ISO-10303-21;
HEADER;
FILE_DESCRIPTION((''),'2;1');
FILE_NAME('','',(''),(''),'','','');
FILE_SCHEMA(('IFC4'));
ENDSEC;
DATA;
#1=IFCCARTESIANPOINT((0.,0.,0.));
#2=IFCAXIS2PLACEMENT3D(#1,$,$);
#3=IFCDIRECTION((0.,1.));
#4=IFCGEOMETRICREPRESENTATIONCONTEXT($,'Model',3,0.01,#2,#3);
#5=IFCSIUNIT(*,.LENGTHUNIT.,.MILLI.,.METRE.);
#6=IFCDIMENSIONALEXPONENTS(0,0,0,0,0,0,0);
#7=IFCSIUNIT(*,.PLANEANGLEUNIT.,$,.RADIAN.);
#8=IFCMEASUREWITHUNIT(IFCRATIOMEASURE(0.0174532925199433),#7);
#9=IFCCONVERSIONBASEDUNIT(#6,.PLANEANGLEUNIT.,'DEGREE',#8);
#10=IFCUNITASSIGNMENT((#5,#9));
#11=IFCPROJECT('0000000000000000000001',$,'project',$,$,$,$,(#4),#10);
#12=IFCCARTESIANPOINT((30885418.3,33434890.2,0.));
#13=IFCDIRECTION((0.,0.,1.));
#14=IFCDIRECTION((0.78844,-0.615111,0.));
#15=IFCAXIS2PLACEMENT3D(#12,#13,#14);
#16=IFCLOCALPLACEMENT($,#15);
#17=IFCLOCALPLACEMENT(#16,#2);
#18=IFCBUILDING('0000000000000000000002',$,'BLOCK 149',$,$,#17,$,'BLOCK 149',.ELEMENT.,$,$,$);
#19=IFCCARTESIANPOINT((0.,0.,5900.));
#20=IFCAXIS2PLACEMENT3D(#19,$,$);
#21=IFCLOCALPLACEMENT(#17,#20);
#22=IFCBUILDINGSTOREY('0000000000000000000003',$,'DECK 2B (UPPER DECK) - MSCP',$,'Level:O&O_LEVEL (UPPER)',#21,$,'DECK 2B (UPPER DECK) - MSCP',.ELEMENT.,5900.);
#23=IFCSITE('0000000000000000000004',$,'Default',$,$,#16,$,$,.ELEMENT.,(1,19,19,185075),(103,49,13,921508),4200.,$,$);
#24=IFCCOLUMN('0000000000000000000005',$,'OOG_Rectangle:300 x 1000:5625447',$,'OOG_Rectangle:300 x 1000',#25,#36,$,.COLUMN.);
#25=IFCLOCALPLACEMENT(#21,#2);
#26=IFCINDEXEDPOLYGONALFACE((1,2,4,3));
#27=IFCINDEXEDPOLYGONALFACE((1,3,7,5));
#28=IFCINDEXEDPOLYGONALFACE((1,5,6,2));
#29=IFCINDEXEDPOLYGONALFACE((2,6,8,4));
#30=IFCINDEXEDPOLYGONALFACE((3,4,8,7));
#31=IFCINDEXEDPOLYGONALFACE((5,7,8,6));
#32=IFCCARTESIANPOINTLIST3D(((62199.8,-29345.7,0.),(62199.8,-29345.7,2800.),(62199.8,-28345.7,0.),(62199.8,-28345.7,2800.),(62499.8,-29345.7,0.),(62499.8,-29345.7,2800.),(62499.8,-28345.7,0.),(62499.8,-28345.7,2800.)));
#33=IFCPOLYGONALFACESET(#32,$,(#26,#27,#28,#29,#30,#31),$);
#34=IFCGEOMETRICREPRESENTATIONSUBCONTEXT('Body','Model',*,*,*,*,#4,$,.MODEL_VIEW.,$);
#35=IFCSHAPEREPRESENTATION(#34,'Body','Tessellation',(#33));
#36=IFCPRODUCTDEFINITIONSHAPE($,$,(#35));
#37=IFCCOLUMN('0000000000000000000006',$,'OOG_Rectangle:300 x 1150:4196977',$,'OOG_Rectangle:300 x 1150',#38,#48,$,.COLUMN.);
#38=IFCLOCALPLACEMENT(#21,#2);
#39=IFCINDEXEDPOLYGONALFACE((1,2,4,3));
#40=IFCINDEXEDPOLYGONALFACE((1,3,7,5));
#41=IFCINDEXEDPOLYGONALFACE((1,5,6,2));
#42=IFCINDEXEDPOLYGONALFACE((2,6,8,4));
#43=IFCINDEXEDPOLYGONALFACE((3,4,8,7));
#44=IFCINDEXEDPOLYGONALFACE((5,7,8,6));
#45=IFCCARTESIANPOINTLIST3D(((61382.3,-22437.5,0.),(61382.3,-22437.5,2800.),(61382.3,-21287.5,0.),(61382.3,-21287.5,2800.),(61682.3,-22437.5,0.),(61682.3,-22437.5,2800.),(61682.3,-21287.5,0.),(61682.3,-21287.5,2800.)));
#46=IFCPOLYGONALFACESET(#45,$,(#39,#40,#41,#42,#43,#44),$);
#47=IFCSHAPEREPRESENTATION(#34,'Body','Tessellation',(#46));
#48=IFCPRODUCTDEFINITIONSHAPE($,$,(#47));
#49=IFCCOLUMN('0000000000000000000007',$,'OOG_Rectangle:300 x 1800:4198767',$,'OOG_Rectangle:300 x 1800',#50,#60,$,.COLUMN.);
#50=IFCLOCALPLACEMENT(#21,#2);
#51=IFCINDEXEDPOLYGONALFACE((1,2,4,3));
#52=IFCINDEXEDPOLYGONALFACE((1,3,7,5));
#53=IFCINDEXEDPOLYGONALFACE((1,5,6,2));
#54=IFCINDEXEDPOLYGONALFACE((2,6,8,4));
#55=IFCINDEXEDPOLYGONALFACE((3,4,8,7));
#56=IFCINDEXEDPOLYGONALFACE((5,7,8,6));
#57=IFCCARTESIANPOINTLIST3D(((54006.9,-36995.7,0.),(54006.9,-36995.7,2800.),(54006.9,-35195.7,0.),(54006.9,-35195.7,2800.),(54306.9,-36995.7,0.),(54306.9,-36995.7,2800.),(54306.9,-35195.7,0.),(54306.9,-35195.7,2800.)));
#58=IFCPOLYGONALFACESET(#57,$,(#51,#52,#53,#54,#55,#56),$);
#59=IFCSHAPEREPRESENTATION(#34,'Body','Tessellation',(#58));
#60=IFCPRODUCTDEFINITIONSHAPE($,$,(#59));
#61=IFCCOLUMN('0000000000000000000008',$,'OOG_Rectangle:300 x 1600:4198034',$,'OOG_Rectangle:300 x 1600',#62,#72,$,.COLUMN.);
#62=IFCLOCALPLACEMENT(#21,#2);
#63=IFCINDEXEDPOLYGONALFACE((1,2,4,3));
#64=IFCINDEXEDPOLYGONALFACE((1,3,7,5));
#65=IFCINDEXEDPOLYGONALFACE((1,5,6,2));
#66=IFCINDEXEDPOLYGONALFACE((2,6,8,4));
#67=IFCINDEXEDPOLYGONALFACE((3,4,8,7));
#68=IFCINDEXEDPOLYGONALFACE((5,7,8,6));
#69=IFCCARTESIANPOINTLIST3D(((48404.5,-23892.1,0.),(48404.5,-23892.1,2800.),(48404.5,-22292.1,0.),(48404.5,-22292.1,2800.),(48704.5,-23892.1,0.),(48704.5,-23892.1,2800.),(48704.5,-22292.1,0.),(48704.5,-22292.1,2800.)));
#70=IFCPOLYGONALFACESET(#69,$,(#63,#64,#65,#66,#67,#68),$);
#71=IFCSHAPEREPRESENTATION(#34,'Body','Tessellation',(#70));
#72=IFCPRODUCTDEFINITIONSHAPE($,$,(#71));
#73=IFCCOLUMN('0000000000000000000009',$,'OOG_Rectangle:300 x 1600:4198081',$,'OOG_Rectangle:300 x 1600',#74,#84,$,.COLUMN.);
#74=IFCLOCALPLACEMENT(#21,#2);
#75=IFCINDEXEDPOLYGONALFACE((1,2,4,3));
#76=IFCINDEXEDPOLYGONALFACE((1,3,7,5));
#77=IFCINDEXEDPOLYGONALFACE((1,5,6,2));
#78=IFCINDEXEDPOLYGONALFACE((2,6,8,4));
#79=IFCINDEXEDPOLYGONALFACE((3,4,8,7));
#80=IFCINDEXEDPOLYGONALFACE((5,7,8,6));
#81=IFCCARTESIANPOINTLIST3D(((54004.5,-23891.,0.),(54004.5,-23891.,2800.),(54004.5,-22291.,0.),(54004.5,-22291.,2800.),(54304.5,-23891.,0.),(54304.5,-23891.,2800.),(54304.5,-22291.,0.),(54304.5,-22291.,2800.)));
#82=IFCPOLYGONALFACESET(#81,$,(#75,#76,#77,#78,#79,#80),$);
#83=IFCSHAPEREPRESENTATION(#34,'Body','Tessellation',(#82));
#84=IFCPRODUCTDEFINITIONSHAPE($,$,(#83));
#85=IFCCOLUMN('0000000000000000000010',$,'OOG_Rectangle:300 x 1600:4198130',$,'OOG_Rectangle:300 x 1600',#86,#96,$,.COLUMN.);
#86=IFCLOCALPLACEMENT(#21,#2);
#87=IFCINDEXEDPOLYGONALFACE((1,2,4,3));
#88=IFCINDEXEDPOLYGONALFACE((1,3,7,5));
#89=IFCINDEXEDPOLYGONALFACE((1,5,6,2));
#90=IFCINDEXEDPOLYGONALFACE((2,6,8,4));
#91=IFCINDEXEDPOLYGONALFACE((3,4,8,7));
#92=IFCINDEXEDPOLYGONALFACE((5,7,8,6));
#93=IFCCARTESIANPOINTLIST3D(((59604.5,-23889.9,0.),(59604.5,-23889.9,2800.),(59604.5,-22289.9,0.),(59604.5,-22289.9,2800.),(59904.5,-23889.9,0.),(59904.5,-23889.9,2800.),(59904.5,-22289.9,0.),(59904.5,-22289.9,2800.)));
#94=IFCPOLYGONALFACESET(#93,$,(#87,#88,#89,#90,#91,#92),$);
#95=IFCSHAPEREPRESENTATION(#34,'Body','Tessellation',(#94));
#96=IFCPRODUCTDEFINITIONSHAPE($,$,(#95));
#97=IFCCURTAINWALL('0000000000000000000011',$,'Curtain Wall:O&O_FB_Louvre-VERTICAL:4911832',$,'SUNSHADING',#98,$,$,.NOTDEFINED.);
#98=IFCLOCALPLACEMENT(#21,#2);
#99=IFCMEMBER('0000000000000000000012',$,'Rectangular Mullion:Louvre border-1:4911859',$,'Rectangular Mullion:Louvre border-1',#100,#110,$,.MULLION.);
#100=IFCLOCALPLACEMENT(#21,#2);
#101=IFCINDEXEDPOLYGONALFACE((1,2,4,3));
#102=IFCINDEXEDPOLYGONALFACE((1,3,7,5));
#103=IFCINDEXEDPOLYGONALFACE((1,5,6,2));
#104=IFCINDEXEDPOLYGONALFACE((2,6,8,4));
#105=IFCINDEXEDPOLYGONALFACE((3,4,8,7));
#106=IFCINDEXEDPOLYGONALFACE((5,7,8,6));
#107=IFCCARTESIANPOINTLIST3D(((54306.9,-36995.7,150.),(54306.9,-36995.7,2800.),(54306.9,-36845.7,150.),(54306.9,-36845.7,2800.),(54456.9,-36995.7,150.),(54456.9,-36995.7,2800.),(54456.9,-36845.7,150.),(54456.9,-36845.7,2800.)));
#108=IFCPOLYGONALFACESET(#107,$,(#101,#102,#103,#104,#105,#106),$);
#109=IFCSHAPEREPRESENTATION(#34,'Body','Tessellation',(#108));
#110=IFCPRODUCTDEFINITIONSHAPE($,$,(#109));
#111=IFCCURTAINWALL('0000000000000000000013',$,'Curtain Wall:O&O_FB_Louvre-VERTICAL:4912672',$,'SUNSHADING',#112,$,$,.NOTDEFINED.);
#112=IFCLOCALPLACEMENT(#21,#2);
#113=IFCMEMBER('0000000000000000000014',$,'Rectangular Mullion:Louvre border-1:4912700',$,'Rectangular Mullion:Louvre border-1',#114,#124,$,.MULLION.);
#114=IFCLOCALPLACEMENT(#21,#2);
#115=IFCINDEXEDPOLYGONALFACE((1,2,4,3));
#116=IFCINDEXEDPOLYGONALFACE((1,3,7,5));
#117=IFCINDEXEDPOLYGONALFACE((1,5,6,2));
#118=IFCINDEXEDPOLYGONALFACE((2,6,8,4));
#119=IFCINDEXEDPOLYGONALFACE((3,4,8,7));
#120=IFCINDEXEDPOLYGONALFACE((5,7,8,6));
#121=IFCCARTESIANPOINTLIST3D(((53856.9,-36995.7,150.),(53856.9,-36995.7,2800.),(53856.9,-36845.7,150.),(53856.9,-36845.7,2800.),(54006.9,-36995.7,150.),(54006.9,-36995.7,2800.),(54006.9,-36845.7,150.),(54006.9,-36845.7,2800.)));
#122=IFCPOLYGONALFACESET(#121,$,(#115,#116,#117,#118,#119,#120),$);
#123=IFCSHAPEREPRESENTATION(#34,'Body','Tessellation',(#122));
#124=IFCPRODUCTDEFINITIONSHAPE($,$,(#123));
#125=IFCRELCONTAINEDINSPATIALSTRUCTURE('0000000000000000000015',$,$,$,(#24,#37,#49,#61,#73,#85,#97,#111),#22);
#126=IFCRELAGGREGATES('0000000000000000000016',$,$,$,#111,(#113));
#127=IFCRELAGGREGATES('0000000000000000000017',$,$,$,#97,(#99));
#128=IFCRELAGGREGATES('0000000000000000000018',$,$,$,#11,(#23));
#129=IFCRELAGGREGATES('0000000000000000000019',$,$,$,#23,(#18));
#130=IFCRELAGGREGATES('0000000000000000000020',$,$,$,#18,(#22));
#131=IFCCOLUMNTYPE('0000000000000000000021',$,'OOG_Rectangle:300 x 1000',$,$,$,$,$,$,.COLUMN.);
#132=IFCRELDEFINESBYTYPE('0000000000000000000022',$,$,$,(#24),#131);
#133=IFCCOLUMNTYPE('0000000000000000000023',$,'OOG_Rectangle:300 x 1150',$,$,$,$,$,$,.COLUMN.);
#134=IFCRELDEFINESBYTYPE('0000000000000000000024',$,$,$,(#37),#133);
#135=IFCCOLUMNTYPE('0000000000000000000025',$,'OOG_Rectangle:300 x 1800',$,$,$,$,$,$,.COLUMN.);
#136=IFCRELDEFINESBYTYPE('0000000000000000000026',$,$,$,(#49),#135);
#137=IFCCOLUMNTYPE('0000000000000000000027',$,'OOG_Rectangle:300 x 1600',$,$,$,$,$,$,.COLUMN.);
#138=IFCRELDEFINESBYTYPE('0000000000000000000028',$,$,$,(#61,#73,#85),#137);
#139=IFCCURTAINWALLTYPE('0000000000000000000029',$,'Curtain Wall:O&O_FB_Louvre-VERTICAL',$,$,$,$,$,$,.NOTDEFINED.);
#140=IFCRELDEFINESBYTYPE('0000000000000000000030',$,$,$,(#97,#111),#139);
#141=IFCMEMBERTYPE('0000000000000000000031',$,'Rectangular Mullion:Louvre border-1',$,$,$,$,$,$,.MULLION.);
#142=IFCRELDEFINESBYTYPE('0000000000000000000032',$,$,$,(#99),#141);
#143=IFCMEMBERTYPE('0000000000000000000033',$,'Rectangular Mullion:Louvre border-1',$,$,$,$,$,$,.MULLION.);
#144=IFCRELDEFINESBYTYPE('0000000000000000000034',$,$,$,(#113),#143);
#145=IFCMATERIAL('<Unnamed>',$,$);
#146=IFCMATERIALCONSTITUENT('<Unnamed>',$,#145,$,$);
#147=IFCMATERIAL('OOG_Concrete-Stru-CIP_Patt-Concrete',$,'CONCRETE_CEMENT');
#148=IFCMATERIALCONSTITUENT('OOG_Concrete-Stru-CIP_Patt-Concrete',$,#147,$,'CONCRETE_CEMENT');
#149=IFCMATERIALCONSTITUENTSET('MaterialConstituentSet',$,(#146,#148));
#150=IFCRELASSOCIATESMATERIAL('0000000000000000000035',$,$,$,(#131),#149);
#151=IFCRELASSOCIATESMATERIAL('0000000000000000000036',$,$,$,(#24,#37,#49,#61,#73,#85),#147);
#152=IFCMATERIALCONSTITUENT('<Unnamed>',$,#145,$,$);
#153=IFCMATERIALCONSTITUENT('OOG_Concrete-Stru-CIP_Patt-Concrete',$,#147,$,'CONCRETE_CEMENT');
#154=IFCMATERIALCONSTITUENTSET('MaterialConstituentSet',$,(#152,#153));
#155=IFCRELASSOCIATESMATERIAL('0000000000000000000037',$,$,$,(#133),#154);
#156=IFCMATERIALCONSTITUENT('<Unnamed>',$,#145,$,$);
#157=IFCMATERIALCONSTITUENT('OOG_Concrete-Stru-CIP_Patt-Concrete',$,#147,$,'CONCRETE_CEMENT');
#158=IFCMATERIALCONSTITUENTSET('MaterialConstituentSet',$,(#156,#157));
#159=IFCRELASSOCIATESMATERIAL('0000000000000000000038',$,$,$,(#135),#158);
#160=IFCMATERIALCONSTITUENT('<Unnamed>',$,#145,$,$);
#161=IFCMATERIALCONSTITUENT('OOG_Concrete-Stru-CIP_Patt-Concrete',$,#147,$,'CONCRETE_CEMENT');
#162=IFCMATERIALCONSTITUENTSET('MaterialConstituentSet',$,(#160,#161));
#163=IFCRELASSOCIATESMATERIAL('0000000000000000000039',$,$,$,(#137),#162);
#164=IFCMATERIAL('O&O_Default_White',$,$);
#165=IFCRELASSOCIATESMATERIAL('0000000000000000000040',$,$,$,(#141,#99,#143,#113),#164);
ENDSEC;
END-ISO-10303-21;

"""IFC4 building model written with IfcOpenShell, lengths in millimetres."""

from ifc_helpers import new_model, entity, si_unit, converted_unit, direction, frame, origin, place, context, subcontext, project, spatial, indexed_curve, outline, extrude, source, transform, mapped, material, constituent, constituent_set, type_object, type_shapes, element, aggregate, save


model = new_model("IFC4")

# Units and contexts
model_context = context("Model", 3, precision=0.01, world=origin(), true_north=direction((0.0, 1.0)))
body_context = subcontext(model_context, "Body", "Model", "MODEL_VIEW")
ifc_project = project(units=[si_unit("LENGTHUNIT", "METRE", prefix="MILLI"), converted_unit("PLANEANGLEUNIT", "DEGREE", entity("IfcRatioMeasure", 0.0174532925199433), si_unit("PLANEANGLEUNIT", "RADIAN"), dimensions=[0, 0, 0, 0, 0, 0, 0])], contexts=[model_context])

# Site, building, storey
site_placement = place(None, frame((30885418.3, 33434890.2, 0.0), z_axis=(0.0, 0.0, 1.0), x_axis=(0.78844, -0.615111, 0.0)))
site = spatial("IfcSite", under=ifc_project, at=site_placement, Name="Default", CompositionType="ELEMENT", RefLatitude=(1, 19, 19, 185075), RefLongitude=(103, 49, 13, 921508), RefElevation=4200.0)
building_placement = place(site_placement, origin())
building = spatial("IfcBuilding", under=site, at=building_placement, Name="BLOCK 149", LongName="BLOCK 149", CompositionType="ELEMENT")
storey_placement = place(building_placement, frame((0.0, 0.0, 5900.0)))
storey = spatial("IfcBuildingStorey", under=building, at=storey_placement, Name="DECK 2B (UPPER DECK) - MSCP", ObjectType="Level:O&O_LEVEL (UPPER)", LongName="DECK 2B (UPPER DECK) - MSCP", CompositionType="ELEMENT", Elevation=5900.0)

# Columns
ifc_material_1 = material(Name="OOG_Concrete-Stru-CIP_Patt-Concrete", Category="CONCRETE_CEMENT")
ifc_material_2 = material(Name="<Unnamed>")
ifc_constituent_1 = constituent(ifc_material_2, Name="<Unnamed>")
ifc_constituent_2 = constituent(ifc_material_1, Name="OOG_Concrete-Stru-CIP_Patt-Concrete", Category="CONCRETE_CEMENT")
ifc_constituent_set_1 = constituent_set(constituents=[ifc_constituent_1, ifc_constituent_2], Name="MaterialConstituentSet")
column_type_1 = type_object("IfcColumnType", Name="OOG_Rectangle:300 x 1000", PredefinedType="COLUMN", material=ifc_constituent_set_1)
shared_shape_1 = source(origin(), body_context, "Body", "SweptSolid", [
    extrude(outline(indexed_curve([(-500.0, -150.0), (500.0, -150.0), (500.0, 150.0), (-500.0, 150.0), (-500.0, -150.0)], self_intersect=False)), frame((0.0, 0.0, 5900.0), z_axis=(0.0, 0.0, 1.0), x_axis=(0.0, -1.0, 0.0)), (0.0, 0.0, 1.0), 2800.0),
])
type_shapes(column_type_1, [shared_shape_1])
column_1_placement = place(storey_placement, frame((62349.8, -28845.7, -5900.0)))
element("IfcColumn", 1, at=column_1_placement, inside=storey, type_object=column_type_1, material=ifc_material_1, Name="OOG_Rectangle:300 x 1000:5625447", ObjectType="OOG_Rectangle:300 x 1000", PredefinedType="COLUMN", context=body_context, shape_type="MappedRepresentation", body=[
    mapped(shared_shape_1, transform((0.0, 0.0, 0.0), scale=1.0)),
])
ifc_constituent_3 = constituent(ifc_material_2, Name="<Unnamed>")
ifc_constituent_4 = constituent(ifc_material_1, Name="OOG_Concrete-Stru-CIP_Patt-Concrete", Category="CONCRETE_CEMENT")
ifc_constituent_set_2 = constituent_set(constituents=[ifc_constituent_3, ifc_constituent_4], Name="MaterialConstituentSet")
column_type_2 = type_object("IfcColumnType", Name="OOG_Rectangle:300 x 1150", PredefinedType="COLUMN", material=ifc_constituent_set_2)
shared_shape_2 = source(origin(), body_context, "Body", "SweptSolid", [
    extrude(outline(indexed_curve([(-575.0, -150.0), (575.0, -150.0), (575.0, 150.0), (-575.0, 150.0), (-575.0, -150.0)], self_intersect=False)), frame((0.0, 0.0, 5900.0), z_axis=(0.0, 0.0, 1.0), x_axis=(0.0, -1.0, 0.0)), (0.0, 0.0, 1.0), 2800.0),
])
type_shapes(column_type_2, [shared_shape_2])
column_2_placement = place(storey_placement, frame((61532.3, -21862.5, -5900.0), z_axis=(0.0, 0.0, 1.0), x_axis=(-1.0, 0.0, 0.0)))
element("IfcColumn", 2, at=column_2_placement, inside=storey, type_object=column_type_2, material=ifc_material_1, Name="OOG_Rectangle:300 x 1150:4196977", ObjectType="OOG_Rectangle:300 x 1150", PredefinedType="COLUMN", context=body_context, shape_type="MappedRepresentation", body=[
    mapped(shared_shape_2, transform((0.0, 0.0, 0.0), scale=1.0)),
])
ifc_constituent_5 = constituent(ifc_material_2, Name="<Unnamed>")
ifc_constituent_6 = constituent(ifc_material_1, Name="OOG_Concrete-Stru-CIP_Patt-Concrete", Category="CONCRETE_CEMENT")
ifc_constituent_set_3 = constituent_set(constituents=[ifc_constituent_5, ifc_constituent_6], Name="MaterialConstituentSet")
column_type_3 = type_object("IfcColumnType", Name="OOG_Rectangle:300 x 1800", PredefinedType="COLUMN", material=ifc_constituent_set_3)
shared_shape_3 = source(origin(), body_context, "Body", "SweptSolid", [
    extrude(outline(indexed_curve([(-900.0, -150.0), (900.0, -150.0), (900.0, 150.0), (-900.0, 150.0), (-900.0, -150.0)], self_intersect=False)), frame((0.0, 0.0, 5900.0), z_axis=(0.0, 0.0, 1.0), x_axis=(0.0, -1.0, 0.0)), (0.0, 0.0, 1.0), 2800.0),
])
type_shapes(column_type_3, [shared_shape_3])
column_3_placement = place(storey_placement, frame((54156.9, -36095.7, -5900.0)))
element("IfcColumn", 3, at=column_3_placement, inside=storey, type_object=column_type_3, material=ifc_material_1, Name="OOG_Rectangle:300 x 1800:4198767", ObjectType="OOG_Rectangle:300 x 1800", PredefinedType="COLUMN", context=body_context, shape_type="MappedRepresentation", body=[
    mapped(shared_shape_3, transform((0.0, 0.0, 0.0), scale=1.0)),
])
ifc_constituent_7 = constituent(ifc_material_2, Name="<Unnamed>")
ifc_constituent_8 = constituent(ifc_material_1, Name="OOG_Concrete-Stru-CIP_Patt-Concrete", Category="CONCRETE_CEMENT")
ifc_constituent_set_4 = constituent_set(constituents=[ifc_constituent_7, ifc_constituent_8], Name="MaterialConstituentSet")
column_type_4 = type_object("IfcColumnType", Name="OOG_Rectangle:300 x 1600", PredefinedType="COLUMN", material=ifc_constituent_set_4)
shared_shape_4 = source(origin(), body_context, "Body", "SweptSolid", [
    extrude(outline(indexed_curve([(-800.0, -150.0), (800.0, -150.0), (800.0, 150.0), (-800.0, 150.0), (-800.0, -150.0)], self_intersect=False)), frame((0.0, 0.0, 5900.0), z_axis=(0.0, 0.0, 1.0), x_axis=(0.0, -1.0, 0.0)), (0.0, 0.0, 1.0), 2800.0),
])
type_shapes(column_type_4, [shared_shape_4])
for number, where, name in (
    (4, (48554.5, -23092.1, -5900.0), "OOG_Rectangle:300 x 1600:4198034"),
    (5, (54154.5, -23091.0, -5900.0), "OOG_Rectangle:300 x 1600:4198081"),
    (6, (59754.5, -23089.9, -5900.0), "OOG_Rectangle:300 x 1600:4198130"),
):
    element("IfcColumn", number, at=place(storey_placement, frame(where)), inside=storey, type_object=column_type_4, material=ifc_material_1, Name=name, ObjectType="OOG_Rectangle:300 x 1600", PredefinedType="COLUMN", context=body_context, shape_type="MappedRepresentation", body=[
        mapped(shared_shape_4, transform((0.0, 0.0, 0.0), scale=1.0)),
    ])

# Curtain walls, members
curtain_wall_type = type_object("IfcCurtainWallType", Name="Curtain Wall:O&O_FB_Louvre-VERTICAL", PredefinedType="NOTDEFINED")
curtain_wall_1_placement = place(storey_placement, frame((0.0, 0.0, -5900.0)))
curtain_wall_1 = element("IfcCurtainWall", 7, at=curtain_wall_1_placement, inside=storey, type_object=curtain_wall_type, Name="Curtain Wall:O&O_FB_Louvre-VERTICAL:4911832", ObjectType="SUNSHADING", PredefinedType="NOTDEFINED")
ifc_material_3 = material(Name="O&O_Default_White")
member_type_1 = type_object("IfcMemberType", Name="Rectangular Mullion:Louvre border-1", PredefinedType="MULLION", material=ifc_material_3)
shared_shape_5 = source(origin(), body_context, "Body", "SweptSolid", [
    extrude(outline(indexed_curve([(-75.0, -75.0), (75.0, -75.0), (75.0, 75.0), (-75.0, 75.0), (-75.0, -75.0)], self_intersect=False)), frame((-75.0, 0.0, -2650.0), z_axis=(0.0, 0.0, 1.0), x_axis=(0.0, -1.0, 0.0)), (0.0, 0.0, 1.0), 2650.0),
])
type_shapes(member_type_1, [shared_shape_5])
placement = place(building_placement, origin())
member_1_placement = place(placement, frame((54306.9, -36920.7, 6050.0), z_axis=(0.0, 0.0, -1.0), x_axis=(-1.0, 0.0, 0.0)))
member_1 = element("IfcMember", 8, at=member_1_placement, type_object=member_type_1, material=ifc_material_3, Name="Rectangular Mullion:Louvre border-1:4911859", ObjectType="Rectangular Mullion:Louvre border-1", PredefinedType="MULLION", context=body_context, shape_type="MappedRepresentation", body=[
    mapped(shared_shape_5, transform((0.0, 0.0, 0.0), scale=1.0)),
])
curtain_wall_2_placement = place(storey_placement, frame((0.0, 0.0, -5900.0)))
curtain_wall_2 = element("IfcCurtainWall", 9, at=curtain_wall_2_placement, inside=storey, type_object=curtain_wall_type, Name="Curtain Wall:O&O_FB_Louvre-VERTICAL:4912672", ObjectType="SUNSHADING", PredefinedType="NOTDEFINED")
member_type_2 = type_object("IfcMemberType", Name="Rectangular Mullion:Louvre border-1", PredefinedType="MULLION", material=ifc_material_3)
shared_shape_6 = source(origin(), body_context, "Body", "SweptSolid", [
    extrude(outline(indexed_curve([(-75.0, -75.0), (75.0, -75.0), (75.0, 75.0), (-75.0, 75.0), (-75.0, -75.0)], self_intersect=False)), frame((-75.0, 0.0, -2650.0), z_axis=(0.0, 0.0, 1.0), x_axis=(0.0, -1.0, 0.0)), (0.0, 0.0, 1.0), 2650.0),
])
type_shapes(member_type_2, [shared_shape_6])
member_2_placement = place(placement, frame((54006.9, -36920.7, 8700.0)))
member_2 = element("IfcMember", 10, at=member_2_placement, type_object=member_type_2, material=ifc_material_3, Name="Rectangular Mullion:Louvre border-1:4912700", ObjectType="Rectangular Mullion:Louvre border-1", PredefinedType="MULLION", context=body_context, shape_type="MappedRepresentation", body=[
    mapped(shared_shape_6, transform((0.0, 0.0, 0.0), scale=1.0)),
])

aggregate(curtain_wall_2, [member_2])
aggregate(curtain_wall_1, [member_1])

save(model, "model.ifc")
